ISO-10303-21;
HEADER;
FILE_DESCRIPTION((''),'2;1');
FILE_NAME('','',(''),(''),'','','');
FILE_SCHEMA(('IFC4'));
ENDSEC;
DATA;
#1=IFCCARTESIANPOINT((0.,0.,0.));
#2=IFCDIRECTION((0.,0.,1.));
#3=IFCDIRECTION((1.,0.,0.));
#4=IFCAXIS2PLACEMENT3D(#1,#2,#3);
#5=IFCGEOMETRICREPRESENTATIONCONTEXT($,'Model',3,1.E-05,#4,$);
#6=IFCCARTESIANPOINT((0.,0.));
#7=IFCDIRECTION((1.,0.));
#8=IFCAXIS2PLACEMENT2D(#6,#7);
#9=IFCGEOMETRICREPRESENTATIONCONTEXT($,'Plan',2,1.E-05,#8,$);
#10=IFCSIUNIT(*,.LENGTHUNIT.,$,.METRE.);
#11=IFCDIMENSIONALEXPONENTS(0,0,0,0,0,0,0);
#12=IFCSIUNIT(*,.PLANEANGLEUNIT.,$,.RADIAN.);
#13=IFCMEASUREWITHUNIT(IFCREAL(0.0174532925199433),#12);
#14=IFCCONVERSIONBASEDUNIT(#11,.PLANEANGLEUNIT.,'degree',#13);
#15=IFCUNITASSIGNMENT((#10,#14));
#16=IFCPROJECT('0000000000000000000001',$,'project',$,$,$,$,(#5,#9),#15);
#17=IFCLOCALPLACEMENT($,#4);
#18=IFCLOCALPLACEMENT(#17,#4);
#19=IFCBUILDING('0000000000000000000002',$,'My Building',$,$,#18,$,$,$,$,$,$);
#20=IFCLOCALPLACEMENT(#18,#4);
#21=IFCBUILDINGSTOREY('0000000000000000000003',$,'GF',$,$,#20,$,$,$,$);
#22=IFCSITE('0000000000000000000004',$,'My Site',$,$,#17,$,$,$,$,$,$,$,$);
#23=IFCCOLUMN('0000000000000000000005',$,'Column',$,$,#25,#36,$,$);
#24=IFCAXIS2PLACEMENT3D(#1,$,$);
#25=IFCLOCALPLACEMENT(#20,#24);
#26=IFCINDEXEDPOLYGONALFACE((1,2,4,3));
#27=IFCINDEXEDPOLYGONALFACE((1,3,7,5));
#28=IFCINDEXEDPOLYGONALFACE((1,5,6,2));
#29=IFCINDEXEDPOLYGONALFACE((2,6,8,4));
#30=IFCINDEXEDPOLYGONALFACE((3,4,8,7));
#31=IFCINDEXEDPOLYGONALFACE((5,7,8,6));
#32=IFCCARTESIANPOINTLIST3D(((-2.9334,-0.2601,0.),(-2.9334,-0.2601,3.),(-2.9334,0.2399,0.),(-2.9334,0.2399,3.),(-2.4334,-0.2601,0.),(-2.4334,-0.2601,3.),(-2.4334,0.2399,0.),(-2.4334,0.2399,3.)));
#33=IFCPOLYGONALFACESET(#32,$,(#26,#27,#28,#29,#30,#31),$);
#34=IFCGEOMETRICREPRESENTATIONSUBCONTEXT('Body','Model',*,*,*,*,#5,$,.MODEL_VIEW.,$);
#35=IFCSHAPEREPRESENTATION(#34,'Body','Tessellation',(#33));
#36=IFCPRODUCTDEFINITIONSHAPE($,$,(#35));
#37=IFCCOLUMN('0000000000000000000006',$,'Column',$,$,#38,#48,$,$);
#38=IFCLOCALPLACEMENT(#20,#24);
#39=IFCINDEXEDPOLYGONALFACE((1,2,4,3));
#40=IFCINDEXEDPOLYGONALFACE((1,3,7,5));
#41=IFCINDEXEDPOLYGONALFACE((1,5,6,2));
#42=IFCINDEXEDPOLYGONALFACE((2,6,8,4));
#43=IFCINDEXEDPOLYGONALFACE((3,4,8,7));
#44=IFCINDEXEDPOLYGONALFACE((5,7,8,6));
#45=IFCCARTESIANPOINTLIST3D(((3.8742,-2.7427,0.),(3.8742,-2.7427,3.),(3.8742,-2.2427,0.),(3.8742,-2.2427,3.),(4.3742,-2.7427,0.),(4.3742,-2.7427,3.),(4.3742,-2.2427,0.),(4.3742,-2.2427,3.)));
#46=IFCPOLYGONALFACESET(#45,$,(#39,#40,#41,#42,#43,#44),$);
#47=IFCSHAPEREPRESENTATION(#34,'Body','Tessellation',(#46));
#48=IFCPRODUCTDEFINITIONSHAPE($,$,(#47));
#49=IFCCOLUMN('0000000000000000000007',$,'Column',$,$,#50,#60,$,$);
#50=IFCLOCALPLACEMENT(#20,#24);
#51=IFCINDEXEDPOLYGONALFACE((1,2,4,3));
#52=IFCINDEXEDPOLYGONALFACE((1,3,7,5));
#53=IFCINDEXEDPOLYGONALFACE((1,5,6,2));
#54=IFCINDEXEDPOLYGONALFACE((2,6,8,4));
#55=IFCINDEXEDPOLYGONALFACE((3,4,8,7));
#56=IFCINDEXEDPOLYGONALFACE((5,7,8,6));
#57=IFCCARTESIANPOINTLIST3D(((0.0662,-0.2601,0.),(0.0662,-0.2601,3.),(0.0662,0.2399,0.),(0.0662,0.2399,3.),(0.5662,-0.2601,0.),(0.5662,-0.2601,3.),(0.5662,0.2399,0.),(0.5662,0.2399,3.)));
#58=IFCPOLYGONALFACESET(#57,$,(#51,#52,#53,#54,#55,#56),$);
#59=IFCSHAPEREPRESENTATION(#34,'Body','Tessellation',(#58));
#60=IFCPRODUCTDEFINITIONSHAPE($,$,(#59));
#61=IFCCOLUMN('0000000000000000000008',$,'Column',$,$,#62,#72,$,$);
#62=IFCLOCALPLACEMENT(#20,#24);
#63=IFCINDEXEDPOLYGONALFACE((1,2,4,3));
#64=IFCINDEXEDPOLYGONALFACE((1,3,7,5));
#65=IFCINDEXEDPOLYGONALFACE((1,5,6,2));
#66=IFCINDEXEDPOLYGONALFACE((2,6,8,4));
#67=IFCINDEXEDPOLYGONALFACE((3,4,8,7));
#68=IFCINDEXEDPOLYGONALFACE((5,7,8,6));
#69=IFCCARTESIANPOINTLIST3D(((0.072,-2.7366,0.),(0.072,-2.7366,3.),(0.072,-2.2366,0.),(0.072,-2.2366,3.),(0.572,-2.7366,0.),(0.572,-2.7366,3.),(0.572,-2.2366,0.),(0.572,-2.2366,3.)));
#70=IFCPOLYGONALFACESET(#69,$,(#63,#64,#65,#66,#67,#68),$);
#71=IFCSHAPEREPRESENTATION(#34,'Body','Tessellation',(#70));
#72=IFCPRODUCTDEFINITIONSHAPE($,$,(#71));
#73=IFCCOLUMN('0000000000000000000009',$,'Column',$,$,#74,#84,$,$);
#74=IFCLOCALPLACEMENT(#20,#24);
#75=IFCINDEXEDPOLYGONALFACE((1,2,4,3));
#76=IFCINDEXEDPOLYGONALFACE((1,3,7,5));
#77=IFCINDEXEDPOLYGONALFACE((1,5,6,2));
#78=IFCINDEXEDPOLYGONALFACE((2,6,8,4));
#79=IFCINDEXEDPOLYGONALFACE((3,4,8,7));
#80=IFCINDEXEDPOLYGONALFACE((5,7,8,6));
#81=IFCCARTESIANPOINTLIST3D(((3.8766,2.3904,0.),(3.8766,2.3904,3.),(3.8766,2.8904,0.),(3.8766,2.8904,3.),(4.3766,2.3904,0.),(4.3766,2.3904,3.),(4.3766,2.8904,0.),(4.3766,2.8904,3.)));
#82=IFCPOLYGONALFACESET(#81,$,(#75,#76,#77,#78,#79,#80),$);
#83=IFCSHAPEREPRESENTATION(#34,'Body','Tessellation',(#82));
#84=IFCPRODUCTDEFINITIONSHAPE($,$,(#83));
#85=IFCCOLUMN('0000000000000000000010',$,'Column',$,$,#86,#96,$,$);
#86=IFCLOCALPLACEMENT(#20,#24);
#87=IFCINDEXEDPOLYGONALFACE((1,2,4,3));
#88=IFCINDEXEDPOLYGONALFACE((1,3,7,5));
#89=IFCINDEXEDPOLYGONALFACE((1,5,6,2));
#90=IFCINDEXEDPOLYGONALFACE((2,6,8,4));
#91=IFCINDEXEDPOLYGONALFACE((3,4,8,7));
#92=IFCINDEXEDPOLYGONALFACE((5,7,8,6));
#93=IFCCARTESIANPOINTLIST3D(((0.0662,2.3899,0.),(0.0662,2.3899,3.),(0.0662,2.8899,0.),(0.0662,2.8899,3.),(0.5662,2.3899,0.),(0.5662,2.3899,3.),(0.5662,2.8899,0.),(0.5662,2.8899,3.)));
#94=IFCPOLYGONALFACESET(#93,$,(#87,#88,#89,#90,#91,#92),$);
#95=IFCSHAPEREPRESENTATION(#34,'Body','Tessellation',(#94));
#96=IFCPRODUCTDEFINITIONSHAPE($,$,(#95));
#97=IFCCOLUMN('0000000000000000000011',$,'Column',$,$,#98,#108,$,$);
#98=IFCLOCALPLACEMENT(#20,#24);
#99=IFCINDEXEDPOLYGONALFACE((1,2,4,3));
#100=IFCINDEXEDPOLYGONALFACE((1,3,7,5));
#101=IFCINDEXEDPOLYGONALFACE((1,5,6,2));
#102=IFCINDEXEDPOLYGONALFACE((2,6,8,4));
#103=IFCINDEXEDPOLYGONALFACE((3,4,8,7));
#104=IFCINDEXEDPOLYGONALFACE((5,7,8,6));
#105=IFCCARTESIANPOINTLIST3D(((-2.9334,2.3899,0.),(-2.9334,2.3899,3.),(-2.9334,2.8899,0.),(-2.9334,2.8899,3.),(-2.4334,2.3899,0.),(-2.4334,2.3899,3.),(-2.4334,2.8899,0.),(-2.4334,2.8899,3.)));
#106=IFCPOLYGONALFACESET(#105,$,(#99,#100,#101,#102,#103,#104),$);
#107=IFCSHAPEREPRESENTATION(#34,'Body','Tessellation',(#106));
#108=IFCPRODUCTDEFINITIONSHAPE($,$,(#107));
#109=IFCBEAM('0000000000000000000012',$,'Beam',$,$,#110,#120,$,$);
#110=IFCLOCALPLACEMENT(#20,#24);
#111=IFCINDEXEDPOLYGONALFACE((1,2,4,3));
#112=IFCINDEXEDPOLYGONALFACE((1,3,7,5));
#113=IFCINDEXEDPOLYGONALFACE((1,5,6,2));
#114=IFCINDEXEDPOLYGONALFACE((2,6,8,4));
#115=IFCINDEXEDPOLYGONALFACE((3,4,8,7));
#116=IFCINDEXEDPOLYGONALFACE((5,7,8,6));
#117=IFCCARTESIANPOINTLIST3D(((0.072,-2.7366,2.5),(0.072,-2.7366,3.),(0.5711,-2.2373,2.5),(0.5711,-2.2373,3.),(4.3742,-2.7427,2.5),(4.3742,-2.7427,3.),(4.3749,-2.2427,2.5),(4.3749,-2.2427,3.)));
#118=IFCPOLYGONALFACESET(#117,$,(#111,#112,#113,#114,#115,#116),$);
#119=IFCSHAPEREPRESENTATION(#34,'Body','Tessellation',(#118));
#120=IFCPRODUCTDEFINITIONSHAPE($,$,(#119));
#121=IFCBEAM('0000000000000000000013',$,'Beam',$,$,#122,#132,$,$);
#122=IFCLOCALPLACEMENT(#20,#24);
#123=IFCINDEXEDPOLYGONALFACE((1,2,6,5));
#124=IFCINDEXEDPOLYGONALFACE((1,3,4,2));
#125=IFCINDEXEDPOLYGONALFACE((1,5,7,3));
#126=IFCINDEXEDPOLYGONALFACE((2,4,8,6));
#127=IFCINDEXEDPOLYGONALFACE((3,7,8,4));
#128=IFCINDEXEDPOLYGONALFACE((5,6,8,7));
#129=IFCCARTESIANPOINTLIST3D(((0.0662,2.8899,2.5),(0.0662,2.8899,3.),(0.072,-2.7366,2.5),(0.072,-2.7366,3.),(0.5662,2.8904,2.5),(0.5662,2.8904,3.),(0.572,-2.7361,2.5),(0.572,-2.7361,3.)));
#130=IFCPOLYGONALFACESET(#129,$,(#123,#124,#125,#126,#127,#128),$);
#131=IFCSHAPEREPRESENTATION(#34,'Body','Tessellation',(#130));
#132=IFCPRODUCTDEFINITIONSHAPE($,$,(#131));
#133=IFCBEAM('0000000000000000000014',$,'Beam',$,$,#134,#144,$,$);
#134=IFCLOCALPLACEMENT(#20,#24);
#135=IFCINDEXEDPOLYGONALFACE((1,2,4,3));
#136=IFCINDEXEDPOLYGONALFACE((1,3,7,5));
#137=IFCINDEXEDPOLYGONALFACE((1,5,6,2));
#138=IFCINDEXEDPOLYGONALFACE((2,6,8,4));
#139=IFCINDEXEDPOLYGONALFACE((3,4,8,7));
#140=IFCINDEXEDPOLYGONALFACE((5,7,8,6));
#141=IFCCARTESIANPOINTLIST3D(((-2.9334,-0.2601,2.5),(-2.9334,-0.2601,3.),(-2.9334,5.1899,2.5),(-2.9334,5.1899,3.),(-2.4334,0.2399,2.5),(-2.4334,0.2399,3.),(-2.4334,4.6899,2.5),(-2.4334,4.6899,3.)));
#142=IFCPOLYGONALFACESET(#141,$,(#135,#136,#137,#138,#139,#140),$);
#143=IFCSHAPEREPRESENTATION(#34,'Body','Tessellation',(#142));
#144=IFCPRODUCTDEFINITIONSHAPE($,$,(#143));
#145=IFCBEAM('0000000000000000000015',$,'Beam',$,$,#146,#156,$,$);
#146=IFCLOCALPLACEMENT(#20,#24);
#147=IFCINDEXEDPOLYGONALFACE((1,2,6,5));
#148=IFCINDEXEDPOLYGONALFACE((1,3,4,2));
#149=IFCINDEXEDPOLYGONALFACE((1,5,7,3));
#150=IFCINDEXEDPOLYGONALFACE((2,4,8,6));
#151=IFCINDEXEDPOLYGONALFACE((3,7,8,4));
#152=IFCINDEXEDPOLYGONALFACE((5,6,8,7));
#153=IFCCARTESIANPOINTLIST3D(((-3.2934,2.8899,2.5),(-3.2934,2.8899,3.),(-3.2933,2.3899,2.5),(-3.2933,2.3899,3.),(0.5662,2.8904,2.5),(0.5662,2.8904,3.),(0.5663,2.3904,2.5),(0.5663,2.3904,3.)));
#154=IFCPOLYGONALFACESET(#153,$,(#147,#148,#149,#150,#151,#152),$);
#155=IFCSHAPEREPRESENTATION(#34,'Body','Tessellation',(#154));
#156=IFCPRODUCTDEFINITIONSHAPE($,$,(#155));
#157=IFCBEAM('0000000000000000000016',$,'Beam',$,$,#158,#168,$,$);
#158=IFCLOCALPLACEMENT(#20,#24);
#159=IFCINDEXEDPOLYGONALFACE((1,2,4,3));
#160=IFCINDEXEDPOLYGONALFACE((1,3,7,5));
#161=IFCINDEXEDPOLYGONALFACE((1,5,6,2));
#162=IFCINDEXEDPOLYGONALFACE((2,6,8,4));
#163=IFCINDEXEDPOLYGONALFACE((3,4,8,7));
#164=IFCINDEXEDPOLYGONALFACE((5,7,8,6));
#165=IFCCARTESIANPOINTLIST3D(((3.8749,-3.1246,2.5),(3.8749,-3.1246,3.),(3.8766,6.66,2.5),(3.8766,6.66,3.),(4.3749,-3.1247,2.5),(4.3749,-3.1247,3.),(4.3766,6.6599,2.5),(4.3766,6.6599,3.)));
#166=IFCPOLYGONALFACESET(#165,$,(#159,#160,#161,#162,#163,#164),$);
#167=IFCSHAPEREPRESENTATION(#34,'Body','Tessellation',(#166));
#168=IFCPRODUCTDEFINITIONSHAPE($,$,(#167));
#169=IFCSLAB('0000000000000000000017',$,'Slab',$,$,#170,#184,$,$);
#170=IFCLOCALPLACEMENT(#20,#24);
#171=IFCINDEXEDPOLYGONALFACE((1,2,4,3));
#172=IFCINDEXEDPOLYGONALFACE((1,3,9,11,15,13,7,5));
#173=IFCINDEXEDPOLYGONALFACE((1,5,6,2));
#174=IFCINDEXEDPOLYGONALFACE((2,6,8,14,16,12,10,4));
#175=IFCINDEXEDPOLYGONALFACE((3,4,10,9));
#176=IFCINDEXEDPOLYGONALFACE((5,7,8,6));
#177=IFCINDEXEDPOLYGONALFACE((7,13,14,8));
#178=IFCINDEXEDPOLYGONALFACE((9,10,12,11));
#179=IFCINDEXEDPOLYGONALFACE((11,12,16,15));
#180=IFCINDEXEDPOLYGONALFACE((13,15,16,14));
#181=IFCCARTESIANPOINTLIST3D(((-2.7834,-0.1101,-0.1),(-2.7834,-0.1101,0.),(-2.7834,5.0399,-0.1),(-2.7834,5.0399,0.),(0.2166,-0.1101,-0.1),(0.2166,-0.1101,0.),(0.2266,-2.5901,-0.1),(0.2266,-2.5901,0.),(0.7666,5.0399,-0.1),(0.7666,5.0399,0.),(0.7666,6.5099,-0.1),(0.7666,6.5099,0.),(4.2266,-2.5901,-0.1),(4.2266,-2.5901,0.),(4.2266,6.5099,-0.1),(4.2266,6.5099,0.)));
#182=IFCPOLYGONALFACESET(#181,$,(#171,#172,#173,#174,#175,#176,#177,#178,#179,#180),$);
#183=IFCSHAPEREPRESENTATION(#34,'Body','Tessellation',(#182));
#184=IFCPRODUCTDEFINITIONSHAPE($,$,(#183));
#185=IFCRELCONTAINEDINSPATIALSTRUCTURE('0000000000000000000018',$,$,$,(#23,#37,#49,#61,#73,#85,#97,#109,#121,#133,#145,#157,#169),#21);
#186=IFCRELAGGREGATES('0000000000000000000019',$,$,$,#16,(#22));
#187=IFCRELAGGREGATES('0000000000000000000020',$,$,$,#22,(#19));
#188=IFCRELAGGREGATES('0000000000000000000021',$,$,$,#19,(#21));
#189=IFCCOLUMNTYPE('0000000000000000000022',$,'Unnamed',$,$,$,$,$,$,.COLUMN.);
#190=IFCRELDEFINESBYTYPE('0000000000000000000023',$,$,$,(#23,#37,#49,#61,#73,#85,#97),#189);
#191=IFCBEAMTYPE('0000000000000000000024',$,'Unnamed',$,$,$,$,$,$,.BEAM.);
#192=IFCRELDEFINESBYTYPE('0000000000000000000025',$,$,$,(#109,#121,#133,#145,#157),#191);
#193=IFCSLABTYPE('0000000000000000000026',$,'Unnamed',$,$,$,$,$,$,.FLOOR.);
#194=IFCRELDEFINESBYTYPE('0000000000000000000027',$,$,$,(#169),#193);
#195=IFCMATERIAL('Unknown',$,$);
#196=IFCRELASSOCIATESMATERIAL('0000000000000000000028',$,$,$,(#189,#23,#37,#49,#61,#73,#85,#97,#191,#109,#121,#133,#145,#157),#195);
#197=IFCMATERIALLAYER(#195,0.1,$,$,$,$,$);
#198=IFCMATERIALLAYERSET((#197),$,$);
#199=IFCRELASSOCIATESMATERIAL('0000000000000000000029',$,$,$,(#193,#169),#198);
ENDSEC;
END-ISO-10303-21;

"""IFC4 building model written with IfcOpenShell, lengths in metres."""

from ifc_helpers import new_model, entity, si_unit, converted_unit, frame, origin_with_axes, origin_2d_with_axis, place, context, subcontext, project, spatial, indexed_curve, rectangle, outline, extrude, clip, halfspace, material, layer, layer_set, layer_usage, material_profile, profile_set, profile_usage, type_object, element, save


model = new_model("IFC4")

# Units and contexts
model_context = context("Model", 3, precision=1e-05, world=origin_with_axes())
plan_context = context("Plan", 2, precision=1e-05, world=origin_2d_with_axis())
body_context_1 = subcontext(model_context, "Body", "Model", "MODEL_VIEW")
ifc_project = project(units=[si_unit("LENGTHUNIT", "METRE"), converted_unit("PLANEANGLEUNIT", "degree", entity("IfcReal", 0.0174532925199433), si_unit("PLANEANGLEUNIT", "RADIAN"), dimensions=[0, 0, 0, 0, 0, 0, 0])], contexts=[model_context, plan_context])

# Site, building, storey
site_placement = place(None, origin_with_axes())
site = spatial("IfcSite", under=ifc_project, at=site_placement, Name="My Site")
building_placement = place(site_placement, origin_with_axes())
building = spatial("IfcBuilding", under=site, at=building_placement, Name="My Building")
storey_placement = place(building_placement, origin_with_axes())
storey = spatial("IfcBuildingStorey", under=building, at=storey_placement, Name="GF")

# Columns
ifc_material_1 = material(Name="Unknown")
ifc_material_profile_1 = material_profile(ifc_material_1, rectangle(XDim=0.5, YDim=0.5))
ifc_profile_set_1 = profile_set([ifc_material_profile_1])
ifc_profile_usage_1 = profile_usage(ifc_profile_set_1, cardinal=5)
column_type = type_object("IfcColumnType", Name="Unnamed", PredefinedType="COLUMN", material=ifc_profile_set_1)
column_1_placement = place(storey_placement, frame((-2.6834, -0.0101, 0.0), z_axis=(0.0, 0.0, 1.0), x_axis=(1.0, 0.0, 0.0)))
element("IfcColumn", 1, at=column_1_placement, inside=storey, type_object=column_type, material=ifc_profile_usage_1, Name="Column", context=body_context_1, shape_type="SweptSolid", body=[
    extrude(rectangle(XDim=0.5, YDim=0.5), origin_with_axes(), (0.0, 0.0, 1.0), 3.0),
])
ifc_profile_usage_2 = profile_usage(ifc_profile_set_1, cardinal=5)
column_2_placement = place(storey_placement, frame((4.1242, -2.4927, 0.0), z_axis=(0.0, 0.0, 1.0), x_axis=(1.0, 0.0, 0.0)))
element("IfcColumn", 2, at=column_2_placement, inside=storey, type_object=column_type, material=ifc_profile_usage_2, Name="Column", context=body_context_1, shape_type="SweptSolid", body=[
    extrude(rectangle(XDim=0.5, YDim=0.5), origin_with_axes(), (0.0, 0.0, 1.0), 3.0),
])
ifc_profile_usage_3 = profile_usage(ifc_profile_set_1, cardinal=5)
column_3_placement = place(storey_placement, frame((0.3162, -0.0101, 0.0), z_axis=(0.0, 0.0, 1.0), x_axis=(1.0, 0.0, 0.0)))
element("IfcColumn", 3, at=column_3_placement, inside=storey, type_object=column_type, material=ifc_profile_usage_3, Name="Column", context=body_context_1, shape_type="SweptSolid", body=[
    extrude(rectangle(XDim=0.5, YDim=0.5), origin_with_axes(), (0.0, 0.0, 1.0), 3.0),
])
ifc_profile_usage_4 = profile_usage(ifc_profile_set_1, cardinal=5)
column_4_placement = place(storey_placement, frame((0.322, -2.4866, 0.0), z_axis=(0.0, 0.0, 1.0), x_axis=(1.0, 0.0, 0.0)))
element("IfcColumn", 4, at=column_4_placement, inside=storey, type_object=column_type, material=ifc_profile_usage_4, Name="Column", context=body_context_1, shape_type="SweptSolid", body=[
    extrude(rectangle(XDim=0.5, YDim=0.5), origin_with_axes(), (0.0, 0.0, 1.0), 3.0),
])
ifc_profile_usage_5 = profile_usage(ifc_profile_set_1, cardinal=5)
column_5_placement = place(storey_placement, frame((4.1266, 2.6404, 0.0), z_axis=(0.0, 0.0, 1.0), x_axis=(1.0, 0.0, 0.0)))
element("IfcColumn", 5, at=column_5_placement, inside=storey, type_object=column_type, material=ifc_profile_usage_5, Name="Column", context=body_context_1, shape_type="SweptSolid", body=[
    extrude(rectangle(XDim=0.5, YDim=0.5), origin_with_axes(), (0.0, 0.0, 1.0), 3.0),
])
ifc_profile_usage_6 = profile_usage(ifc_profile_set_1, cardinal=5)
column_6_placement = place(storey_placement, frame((0.3162, 2.6399, 0.0), z_axis=(0.0, 0.0, 1.0), x_axis=(1.0, 0.0, 0.0)))
element("IfcColumn", 6, at=column_6_placement, inside=storey, type_object=column_type, material=ifc_profile_usage_6, Name="Column", context=body_context_1, shape_type="SweptSolid", body=[
    extrude(rectangle(XDim=0.5, YDim=0.5), origin_with_axes(), (0.0, 0.0, 1.0), 3.0),
])
ifc_profile_usage_7 = profile_usage(ifc_profile_set_1, cardinal=5)
column_7_placement = place(storey_placement, frame((-2.6834, 2.6399, 0.0), z_axis=(0.0, 0.0, 1.0), x_axis=(1.0, 0.0, 0.0)))
element("IfcColumn", 7, at=column_7_placement, inside=storey, type_object=column_type, material=ifc_profile_usage_7, Name="Column", context=body_context_1, shape_type="SweptSolid", body=[
    extrude(rectangle(XDim=0.5, YDim=0.5), origin_with_axes(), (0.0, 0.0, 1.0), 3.0),
])

# Beams
ifc_material_profile_2 = material_profile(ifc_material_1, rectangle(XDim=0.5, YDim=0.5))
ifc_profile_set_2 = profile_set([ifc_material_profile_2])
ifc_profile_usage_8 = profile_usage(ifc_profile_set_2, cardinal=7)
beam_type = type_object("IfcBeamType", Name="Unnamed", PredefinedType="BEAM", material=ifc_profile_set_2)
beam_1_placement = place(storey_placement, frame((4.3742, -2.7427, 3.0), z_axis=(-0.999999, 0.001415, 0.0), x_axis=(-0.001415, -0.999999, 0.0)))
element("IfcBeam", 8, at=beam_1_placement, inside=storey, type_object=beam_type, material=ifc_profile_usage_8, Name="Beam", context=body_context_1, shape_type="Clipping", body=[
    clip(extrude(rectangle(XDim=0.5, YDim=0.5), frame((-0.25, -0.25, 0.0), z_axis=(0.0, 0.0, 1.0), x_axis=(1.0, 0.0, 0.0)), (0.0, 0.0, 1.0), 4.8022), halfspace(frame((0.0, -3.0, 4.3022), z_axis=(-0.705913, 0.0, 0.708298), x_axis=(0.0, 1.0, 0.0)), False)),
])
ifc_profile_usage_9 = profile_usage(ifc_profile_set_2, cardinal=7)
beam_2_placement = place(storey_placement, frame((0.072, -2.7366, 3.0), z_axis=(-0.001036, 0.999999, 0.0), x_axis=(-0.999999, -0.001036, 0.0)))
element("IfcBeam", 9, at=beam_2_placement, inside=storey, type_object=beam_type, material=ifc_profile_usage_9, Name="Beam", context=body_context_1, shape_type="SweptSolid", body=[
    extrude(rectangle(XDim=0.5, YDim=0.5), frame((-0.25, -0.25, 0.0), z_axis=(0.0, 0.0, 1.0), x_axis=(1.0, 0.0, 0.0)), (0.0, 0.0, 1.0), 5.6265),
])
ifc_profile_usage_10 = profile_usage(ifc_profile_set_2, cardinal=7)
beam_3_placement = place(storey_placement, frame((-2.9334, -0.2601, 3.0), z_axis=(0.0, 1.0, 0.0), x_axis=(-1.0, 0.0, 0.0)))
element("IfcBeam", 10, at=beam_3_placement, inside=storey, type_object=beam_type, material=ifc_profile_usage_10, Name="Beam", context=body_context_1, shape_type="Clipping", body=[
    clip(clip(extrude(rectangle(XDim=0.5, YDim=0.5), frame((-0.25, -0.25, 0.0), z_axis=(0.0, 0.0, 1.0), x_axis=(1.0, 0.0, 0.0)), (0.0, 0.0, 1.0), 5.45), halfspace(frame((0.0, -3.0, 5.45), z_axis=(-0.707107, 0.0, 0.707107), x_axis=(0.0, 1.0, 0.0)), False)), halfspace(frame((0.0, -3.0, 0.0), z_axis=(-0.707107, 0.0, -0.707107), x_axis=(0.0, 1.0, 0.0)), False)),
])
ifc_profile_usage_11 = profile_usage(ifc_profile_set_2, cardinal=9)
beam_4_placement = place(storey_placement, frame((0.5662, 2.8904, 3.0), z_axis=(-1.0, -0.000134, 0.0), x_axis=(0.000134, -1.0, 0.0)))
element("IfcBeam", 11, at=beam_4_placement, inside=storey, type_object=beam_type, material=ifc_profile_usage_11, Name="Beam", context=body_context_1, shape_type="SweptSolid", body=[
    extrude(rectangle(XDim=0.5, YDim=0.5), frame((0.25, -0.25, 0.0), z_axis=(0.0, 0.0, 1.0), x_axis=(1.0, 0.0, 0.0)), (0.0, 0.0, 1.0), 3.8596),
])
ifc_profile_usage_12 = profile_usage(ifc_profile_set_2, cardinal=9)
beam_5_placement = place(storey_placement, frame((4.3749, -3.1247, 3.0), z_axis=(0.000173, 1.0, 0.0), x_axis=(-1.0, 0.000173, 0.0)))
element("IfcBeam", 12, at=beam_5_placement, inside=storey, type_object=beam_type, material=ifc_profile_usage_12, Name="Beam", context=body_context_1, shape_type="SweptSolid", body=[
    extrude(rectangle(XDim=0.5, YDim=0.5), frame((0.25, -0.25, 0.0), z_axis=(0.0, 0.0, 1.0), x_axis=(1.0, 0.0, 0.0)), (0.0, 0.0, 1.0), 9.7846),
])

# Slab
ifc_layer_1 = layer(ifc_material_1, 0.1)
ifc_layer_set_1 = layer_set([ifc_layer_1])
ifc_layer_usage_1 = layer_usage(ifc_layer_set_1, "AXIS3", "POSITIVE", -0.1)
slab_type_1 = type_object("IfcSlabType", Name="Unnamed", PredefinedType="FLOOR", material=ifc_layer_set_1)
slab_1_placement = place(storey_placement, frame((4.2266, -2.5901, 0.0), z_axis=(0.0, 0.0, 1.0), x_axis=(1.0, 0.0, 0.0)))
element("IfcSlab", 13, at=slab_1_placement, inside=storey, type_object=slab_type_1, material=ifc_layer_usage_1, Name="Slab", context=body_context_1, shape_type="SweptSolid", body=[
    extrude(outline(indexed_curve([(0.0, 0.0), (0.0, 9.1), (-3.46, 9.1), (-3.46, 7.63), (-7.01, 7.63), (-7.01, 2.48), (-4.01, 2.48), (-4.0, 0.0), (0.0, 0.0)])), frame((0.0, 0.0, -0.1), z_axis=(0.0, 0.0, 1.0), x_axis=(1.0, 0.0, 0.0)), (0.0, 0.0, 1.0), 0.1),
])

save(model, "model.ifc")
